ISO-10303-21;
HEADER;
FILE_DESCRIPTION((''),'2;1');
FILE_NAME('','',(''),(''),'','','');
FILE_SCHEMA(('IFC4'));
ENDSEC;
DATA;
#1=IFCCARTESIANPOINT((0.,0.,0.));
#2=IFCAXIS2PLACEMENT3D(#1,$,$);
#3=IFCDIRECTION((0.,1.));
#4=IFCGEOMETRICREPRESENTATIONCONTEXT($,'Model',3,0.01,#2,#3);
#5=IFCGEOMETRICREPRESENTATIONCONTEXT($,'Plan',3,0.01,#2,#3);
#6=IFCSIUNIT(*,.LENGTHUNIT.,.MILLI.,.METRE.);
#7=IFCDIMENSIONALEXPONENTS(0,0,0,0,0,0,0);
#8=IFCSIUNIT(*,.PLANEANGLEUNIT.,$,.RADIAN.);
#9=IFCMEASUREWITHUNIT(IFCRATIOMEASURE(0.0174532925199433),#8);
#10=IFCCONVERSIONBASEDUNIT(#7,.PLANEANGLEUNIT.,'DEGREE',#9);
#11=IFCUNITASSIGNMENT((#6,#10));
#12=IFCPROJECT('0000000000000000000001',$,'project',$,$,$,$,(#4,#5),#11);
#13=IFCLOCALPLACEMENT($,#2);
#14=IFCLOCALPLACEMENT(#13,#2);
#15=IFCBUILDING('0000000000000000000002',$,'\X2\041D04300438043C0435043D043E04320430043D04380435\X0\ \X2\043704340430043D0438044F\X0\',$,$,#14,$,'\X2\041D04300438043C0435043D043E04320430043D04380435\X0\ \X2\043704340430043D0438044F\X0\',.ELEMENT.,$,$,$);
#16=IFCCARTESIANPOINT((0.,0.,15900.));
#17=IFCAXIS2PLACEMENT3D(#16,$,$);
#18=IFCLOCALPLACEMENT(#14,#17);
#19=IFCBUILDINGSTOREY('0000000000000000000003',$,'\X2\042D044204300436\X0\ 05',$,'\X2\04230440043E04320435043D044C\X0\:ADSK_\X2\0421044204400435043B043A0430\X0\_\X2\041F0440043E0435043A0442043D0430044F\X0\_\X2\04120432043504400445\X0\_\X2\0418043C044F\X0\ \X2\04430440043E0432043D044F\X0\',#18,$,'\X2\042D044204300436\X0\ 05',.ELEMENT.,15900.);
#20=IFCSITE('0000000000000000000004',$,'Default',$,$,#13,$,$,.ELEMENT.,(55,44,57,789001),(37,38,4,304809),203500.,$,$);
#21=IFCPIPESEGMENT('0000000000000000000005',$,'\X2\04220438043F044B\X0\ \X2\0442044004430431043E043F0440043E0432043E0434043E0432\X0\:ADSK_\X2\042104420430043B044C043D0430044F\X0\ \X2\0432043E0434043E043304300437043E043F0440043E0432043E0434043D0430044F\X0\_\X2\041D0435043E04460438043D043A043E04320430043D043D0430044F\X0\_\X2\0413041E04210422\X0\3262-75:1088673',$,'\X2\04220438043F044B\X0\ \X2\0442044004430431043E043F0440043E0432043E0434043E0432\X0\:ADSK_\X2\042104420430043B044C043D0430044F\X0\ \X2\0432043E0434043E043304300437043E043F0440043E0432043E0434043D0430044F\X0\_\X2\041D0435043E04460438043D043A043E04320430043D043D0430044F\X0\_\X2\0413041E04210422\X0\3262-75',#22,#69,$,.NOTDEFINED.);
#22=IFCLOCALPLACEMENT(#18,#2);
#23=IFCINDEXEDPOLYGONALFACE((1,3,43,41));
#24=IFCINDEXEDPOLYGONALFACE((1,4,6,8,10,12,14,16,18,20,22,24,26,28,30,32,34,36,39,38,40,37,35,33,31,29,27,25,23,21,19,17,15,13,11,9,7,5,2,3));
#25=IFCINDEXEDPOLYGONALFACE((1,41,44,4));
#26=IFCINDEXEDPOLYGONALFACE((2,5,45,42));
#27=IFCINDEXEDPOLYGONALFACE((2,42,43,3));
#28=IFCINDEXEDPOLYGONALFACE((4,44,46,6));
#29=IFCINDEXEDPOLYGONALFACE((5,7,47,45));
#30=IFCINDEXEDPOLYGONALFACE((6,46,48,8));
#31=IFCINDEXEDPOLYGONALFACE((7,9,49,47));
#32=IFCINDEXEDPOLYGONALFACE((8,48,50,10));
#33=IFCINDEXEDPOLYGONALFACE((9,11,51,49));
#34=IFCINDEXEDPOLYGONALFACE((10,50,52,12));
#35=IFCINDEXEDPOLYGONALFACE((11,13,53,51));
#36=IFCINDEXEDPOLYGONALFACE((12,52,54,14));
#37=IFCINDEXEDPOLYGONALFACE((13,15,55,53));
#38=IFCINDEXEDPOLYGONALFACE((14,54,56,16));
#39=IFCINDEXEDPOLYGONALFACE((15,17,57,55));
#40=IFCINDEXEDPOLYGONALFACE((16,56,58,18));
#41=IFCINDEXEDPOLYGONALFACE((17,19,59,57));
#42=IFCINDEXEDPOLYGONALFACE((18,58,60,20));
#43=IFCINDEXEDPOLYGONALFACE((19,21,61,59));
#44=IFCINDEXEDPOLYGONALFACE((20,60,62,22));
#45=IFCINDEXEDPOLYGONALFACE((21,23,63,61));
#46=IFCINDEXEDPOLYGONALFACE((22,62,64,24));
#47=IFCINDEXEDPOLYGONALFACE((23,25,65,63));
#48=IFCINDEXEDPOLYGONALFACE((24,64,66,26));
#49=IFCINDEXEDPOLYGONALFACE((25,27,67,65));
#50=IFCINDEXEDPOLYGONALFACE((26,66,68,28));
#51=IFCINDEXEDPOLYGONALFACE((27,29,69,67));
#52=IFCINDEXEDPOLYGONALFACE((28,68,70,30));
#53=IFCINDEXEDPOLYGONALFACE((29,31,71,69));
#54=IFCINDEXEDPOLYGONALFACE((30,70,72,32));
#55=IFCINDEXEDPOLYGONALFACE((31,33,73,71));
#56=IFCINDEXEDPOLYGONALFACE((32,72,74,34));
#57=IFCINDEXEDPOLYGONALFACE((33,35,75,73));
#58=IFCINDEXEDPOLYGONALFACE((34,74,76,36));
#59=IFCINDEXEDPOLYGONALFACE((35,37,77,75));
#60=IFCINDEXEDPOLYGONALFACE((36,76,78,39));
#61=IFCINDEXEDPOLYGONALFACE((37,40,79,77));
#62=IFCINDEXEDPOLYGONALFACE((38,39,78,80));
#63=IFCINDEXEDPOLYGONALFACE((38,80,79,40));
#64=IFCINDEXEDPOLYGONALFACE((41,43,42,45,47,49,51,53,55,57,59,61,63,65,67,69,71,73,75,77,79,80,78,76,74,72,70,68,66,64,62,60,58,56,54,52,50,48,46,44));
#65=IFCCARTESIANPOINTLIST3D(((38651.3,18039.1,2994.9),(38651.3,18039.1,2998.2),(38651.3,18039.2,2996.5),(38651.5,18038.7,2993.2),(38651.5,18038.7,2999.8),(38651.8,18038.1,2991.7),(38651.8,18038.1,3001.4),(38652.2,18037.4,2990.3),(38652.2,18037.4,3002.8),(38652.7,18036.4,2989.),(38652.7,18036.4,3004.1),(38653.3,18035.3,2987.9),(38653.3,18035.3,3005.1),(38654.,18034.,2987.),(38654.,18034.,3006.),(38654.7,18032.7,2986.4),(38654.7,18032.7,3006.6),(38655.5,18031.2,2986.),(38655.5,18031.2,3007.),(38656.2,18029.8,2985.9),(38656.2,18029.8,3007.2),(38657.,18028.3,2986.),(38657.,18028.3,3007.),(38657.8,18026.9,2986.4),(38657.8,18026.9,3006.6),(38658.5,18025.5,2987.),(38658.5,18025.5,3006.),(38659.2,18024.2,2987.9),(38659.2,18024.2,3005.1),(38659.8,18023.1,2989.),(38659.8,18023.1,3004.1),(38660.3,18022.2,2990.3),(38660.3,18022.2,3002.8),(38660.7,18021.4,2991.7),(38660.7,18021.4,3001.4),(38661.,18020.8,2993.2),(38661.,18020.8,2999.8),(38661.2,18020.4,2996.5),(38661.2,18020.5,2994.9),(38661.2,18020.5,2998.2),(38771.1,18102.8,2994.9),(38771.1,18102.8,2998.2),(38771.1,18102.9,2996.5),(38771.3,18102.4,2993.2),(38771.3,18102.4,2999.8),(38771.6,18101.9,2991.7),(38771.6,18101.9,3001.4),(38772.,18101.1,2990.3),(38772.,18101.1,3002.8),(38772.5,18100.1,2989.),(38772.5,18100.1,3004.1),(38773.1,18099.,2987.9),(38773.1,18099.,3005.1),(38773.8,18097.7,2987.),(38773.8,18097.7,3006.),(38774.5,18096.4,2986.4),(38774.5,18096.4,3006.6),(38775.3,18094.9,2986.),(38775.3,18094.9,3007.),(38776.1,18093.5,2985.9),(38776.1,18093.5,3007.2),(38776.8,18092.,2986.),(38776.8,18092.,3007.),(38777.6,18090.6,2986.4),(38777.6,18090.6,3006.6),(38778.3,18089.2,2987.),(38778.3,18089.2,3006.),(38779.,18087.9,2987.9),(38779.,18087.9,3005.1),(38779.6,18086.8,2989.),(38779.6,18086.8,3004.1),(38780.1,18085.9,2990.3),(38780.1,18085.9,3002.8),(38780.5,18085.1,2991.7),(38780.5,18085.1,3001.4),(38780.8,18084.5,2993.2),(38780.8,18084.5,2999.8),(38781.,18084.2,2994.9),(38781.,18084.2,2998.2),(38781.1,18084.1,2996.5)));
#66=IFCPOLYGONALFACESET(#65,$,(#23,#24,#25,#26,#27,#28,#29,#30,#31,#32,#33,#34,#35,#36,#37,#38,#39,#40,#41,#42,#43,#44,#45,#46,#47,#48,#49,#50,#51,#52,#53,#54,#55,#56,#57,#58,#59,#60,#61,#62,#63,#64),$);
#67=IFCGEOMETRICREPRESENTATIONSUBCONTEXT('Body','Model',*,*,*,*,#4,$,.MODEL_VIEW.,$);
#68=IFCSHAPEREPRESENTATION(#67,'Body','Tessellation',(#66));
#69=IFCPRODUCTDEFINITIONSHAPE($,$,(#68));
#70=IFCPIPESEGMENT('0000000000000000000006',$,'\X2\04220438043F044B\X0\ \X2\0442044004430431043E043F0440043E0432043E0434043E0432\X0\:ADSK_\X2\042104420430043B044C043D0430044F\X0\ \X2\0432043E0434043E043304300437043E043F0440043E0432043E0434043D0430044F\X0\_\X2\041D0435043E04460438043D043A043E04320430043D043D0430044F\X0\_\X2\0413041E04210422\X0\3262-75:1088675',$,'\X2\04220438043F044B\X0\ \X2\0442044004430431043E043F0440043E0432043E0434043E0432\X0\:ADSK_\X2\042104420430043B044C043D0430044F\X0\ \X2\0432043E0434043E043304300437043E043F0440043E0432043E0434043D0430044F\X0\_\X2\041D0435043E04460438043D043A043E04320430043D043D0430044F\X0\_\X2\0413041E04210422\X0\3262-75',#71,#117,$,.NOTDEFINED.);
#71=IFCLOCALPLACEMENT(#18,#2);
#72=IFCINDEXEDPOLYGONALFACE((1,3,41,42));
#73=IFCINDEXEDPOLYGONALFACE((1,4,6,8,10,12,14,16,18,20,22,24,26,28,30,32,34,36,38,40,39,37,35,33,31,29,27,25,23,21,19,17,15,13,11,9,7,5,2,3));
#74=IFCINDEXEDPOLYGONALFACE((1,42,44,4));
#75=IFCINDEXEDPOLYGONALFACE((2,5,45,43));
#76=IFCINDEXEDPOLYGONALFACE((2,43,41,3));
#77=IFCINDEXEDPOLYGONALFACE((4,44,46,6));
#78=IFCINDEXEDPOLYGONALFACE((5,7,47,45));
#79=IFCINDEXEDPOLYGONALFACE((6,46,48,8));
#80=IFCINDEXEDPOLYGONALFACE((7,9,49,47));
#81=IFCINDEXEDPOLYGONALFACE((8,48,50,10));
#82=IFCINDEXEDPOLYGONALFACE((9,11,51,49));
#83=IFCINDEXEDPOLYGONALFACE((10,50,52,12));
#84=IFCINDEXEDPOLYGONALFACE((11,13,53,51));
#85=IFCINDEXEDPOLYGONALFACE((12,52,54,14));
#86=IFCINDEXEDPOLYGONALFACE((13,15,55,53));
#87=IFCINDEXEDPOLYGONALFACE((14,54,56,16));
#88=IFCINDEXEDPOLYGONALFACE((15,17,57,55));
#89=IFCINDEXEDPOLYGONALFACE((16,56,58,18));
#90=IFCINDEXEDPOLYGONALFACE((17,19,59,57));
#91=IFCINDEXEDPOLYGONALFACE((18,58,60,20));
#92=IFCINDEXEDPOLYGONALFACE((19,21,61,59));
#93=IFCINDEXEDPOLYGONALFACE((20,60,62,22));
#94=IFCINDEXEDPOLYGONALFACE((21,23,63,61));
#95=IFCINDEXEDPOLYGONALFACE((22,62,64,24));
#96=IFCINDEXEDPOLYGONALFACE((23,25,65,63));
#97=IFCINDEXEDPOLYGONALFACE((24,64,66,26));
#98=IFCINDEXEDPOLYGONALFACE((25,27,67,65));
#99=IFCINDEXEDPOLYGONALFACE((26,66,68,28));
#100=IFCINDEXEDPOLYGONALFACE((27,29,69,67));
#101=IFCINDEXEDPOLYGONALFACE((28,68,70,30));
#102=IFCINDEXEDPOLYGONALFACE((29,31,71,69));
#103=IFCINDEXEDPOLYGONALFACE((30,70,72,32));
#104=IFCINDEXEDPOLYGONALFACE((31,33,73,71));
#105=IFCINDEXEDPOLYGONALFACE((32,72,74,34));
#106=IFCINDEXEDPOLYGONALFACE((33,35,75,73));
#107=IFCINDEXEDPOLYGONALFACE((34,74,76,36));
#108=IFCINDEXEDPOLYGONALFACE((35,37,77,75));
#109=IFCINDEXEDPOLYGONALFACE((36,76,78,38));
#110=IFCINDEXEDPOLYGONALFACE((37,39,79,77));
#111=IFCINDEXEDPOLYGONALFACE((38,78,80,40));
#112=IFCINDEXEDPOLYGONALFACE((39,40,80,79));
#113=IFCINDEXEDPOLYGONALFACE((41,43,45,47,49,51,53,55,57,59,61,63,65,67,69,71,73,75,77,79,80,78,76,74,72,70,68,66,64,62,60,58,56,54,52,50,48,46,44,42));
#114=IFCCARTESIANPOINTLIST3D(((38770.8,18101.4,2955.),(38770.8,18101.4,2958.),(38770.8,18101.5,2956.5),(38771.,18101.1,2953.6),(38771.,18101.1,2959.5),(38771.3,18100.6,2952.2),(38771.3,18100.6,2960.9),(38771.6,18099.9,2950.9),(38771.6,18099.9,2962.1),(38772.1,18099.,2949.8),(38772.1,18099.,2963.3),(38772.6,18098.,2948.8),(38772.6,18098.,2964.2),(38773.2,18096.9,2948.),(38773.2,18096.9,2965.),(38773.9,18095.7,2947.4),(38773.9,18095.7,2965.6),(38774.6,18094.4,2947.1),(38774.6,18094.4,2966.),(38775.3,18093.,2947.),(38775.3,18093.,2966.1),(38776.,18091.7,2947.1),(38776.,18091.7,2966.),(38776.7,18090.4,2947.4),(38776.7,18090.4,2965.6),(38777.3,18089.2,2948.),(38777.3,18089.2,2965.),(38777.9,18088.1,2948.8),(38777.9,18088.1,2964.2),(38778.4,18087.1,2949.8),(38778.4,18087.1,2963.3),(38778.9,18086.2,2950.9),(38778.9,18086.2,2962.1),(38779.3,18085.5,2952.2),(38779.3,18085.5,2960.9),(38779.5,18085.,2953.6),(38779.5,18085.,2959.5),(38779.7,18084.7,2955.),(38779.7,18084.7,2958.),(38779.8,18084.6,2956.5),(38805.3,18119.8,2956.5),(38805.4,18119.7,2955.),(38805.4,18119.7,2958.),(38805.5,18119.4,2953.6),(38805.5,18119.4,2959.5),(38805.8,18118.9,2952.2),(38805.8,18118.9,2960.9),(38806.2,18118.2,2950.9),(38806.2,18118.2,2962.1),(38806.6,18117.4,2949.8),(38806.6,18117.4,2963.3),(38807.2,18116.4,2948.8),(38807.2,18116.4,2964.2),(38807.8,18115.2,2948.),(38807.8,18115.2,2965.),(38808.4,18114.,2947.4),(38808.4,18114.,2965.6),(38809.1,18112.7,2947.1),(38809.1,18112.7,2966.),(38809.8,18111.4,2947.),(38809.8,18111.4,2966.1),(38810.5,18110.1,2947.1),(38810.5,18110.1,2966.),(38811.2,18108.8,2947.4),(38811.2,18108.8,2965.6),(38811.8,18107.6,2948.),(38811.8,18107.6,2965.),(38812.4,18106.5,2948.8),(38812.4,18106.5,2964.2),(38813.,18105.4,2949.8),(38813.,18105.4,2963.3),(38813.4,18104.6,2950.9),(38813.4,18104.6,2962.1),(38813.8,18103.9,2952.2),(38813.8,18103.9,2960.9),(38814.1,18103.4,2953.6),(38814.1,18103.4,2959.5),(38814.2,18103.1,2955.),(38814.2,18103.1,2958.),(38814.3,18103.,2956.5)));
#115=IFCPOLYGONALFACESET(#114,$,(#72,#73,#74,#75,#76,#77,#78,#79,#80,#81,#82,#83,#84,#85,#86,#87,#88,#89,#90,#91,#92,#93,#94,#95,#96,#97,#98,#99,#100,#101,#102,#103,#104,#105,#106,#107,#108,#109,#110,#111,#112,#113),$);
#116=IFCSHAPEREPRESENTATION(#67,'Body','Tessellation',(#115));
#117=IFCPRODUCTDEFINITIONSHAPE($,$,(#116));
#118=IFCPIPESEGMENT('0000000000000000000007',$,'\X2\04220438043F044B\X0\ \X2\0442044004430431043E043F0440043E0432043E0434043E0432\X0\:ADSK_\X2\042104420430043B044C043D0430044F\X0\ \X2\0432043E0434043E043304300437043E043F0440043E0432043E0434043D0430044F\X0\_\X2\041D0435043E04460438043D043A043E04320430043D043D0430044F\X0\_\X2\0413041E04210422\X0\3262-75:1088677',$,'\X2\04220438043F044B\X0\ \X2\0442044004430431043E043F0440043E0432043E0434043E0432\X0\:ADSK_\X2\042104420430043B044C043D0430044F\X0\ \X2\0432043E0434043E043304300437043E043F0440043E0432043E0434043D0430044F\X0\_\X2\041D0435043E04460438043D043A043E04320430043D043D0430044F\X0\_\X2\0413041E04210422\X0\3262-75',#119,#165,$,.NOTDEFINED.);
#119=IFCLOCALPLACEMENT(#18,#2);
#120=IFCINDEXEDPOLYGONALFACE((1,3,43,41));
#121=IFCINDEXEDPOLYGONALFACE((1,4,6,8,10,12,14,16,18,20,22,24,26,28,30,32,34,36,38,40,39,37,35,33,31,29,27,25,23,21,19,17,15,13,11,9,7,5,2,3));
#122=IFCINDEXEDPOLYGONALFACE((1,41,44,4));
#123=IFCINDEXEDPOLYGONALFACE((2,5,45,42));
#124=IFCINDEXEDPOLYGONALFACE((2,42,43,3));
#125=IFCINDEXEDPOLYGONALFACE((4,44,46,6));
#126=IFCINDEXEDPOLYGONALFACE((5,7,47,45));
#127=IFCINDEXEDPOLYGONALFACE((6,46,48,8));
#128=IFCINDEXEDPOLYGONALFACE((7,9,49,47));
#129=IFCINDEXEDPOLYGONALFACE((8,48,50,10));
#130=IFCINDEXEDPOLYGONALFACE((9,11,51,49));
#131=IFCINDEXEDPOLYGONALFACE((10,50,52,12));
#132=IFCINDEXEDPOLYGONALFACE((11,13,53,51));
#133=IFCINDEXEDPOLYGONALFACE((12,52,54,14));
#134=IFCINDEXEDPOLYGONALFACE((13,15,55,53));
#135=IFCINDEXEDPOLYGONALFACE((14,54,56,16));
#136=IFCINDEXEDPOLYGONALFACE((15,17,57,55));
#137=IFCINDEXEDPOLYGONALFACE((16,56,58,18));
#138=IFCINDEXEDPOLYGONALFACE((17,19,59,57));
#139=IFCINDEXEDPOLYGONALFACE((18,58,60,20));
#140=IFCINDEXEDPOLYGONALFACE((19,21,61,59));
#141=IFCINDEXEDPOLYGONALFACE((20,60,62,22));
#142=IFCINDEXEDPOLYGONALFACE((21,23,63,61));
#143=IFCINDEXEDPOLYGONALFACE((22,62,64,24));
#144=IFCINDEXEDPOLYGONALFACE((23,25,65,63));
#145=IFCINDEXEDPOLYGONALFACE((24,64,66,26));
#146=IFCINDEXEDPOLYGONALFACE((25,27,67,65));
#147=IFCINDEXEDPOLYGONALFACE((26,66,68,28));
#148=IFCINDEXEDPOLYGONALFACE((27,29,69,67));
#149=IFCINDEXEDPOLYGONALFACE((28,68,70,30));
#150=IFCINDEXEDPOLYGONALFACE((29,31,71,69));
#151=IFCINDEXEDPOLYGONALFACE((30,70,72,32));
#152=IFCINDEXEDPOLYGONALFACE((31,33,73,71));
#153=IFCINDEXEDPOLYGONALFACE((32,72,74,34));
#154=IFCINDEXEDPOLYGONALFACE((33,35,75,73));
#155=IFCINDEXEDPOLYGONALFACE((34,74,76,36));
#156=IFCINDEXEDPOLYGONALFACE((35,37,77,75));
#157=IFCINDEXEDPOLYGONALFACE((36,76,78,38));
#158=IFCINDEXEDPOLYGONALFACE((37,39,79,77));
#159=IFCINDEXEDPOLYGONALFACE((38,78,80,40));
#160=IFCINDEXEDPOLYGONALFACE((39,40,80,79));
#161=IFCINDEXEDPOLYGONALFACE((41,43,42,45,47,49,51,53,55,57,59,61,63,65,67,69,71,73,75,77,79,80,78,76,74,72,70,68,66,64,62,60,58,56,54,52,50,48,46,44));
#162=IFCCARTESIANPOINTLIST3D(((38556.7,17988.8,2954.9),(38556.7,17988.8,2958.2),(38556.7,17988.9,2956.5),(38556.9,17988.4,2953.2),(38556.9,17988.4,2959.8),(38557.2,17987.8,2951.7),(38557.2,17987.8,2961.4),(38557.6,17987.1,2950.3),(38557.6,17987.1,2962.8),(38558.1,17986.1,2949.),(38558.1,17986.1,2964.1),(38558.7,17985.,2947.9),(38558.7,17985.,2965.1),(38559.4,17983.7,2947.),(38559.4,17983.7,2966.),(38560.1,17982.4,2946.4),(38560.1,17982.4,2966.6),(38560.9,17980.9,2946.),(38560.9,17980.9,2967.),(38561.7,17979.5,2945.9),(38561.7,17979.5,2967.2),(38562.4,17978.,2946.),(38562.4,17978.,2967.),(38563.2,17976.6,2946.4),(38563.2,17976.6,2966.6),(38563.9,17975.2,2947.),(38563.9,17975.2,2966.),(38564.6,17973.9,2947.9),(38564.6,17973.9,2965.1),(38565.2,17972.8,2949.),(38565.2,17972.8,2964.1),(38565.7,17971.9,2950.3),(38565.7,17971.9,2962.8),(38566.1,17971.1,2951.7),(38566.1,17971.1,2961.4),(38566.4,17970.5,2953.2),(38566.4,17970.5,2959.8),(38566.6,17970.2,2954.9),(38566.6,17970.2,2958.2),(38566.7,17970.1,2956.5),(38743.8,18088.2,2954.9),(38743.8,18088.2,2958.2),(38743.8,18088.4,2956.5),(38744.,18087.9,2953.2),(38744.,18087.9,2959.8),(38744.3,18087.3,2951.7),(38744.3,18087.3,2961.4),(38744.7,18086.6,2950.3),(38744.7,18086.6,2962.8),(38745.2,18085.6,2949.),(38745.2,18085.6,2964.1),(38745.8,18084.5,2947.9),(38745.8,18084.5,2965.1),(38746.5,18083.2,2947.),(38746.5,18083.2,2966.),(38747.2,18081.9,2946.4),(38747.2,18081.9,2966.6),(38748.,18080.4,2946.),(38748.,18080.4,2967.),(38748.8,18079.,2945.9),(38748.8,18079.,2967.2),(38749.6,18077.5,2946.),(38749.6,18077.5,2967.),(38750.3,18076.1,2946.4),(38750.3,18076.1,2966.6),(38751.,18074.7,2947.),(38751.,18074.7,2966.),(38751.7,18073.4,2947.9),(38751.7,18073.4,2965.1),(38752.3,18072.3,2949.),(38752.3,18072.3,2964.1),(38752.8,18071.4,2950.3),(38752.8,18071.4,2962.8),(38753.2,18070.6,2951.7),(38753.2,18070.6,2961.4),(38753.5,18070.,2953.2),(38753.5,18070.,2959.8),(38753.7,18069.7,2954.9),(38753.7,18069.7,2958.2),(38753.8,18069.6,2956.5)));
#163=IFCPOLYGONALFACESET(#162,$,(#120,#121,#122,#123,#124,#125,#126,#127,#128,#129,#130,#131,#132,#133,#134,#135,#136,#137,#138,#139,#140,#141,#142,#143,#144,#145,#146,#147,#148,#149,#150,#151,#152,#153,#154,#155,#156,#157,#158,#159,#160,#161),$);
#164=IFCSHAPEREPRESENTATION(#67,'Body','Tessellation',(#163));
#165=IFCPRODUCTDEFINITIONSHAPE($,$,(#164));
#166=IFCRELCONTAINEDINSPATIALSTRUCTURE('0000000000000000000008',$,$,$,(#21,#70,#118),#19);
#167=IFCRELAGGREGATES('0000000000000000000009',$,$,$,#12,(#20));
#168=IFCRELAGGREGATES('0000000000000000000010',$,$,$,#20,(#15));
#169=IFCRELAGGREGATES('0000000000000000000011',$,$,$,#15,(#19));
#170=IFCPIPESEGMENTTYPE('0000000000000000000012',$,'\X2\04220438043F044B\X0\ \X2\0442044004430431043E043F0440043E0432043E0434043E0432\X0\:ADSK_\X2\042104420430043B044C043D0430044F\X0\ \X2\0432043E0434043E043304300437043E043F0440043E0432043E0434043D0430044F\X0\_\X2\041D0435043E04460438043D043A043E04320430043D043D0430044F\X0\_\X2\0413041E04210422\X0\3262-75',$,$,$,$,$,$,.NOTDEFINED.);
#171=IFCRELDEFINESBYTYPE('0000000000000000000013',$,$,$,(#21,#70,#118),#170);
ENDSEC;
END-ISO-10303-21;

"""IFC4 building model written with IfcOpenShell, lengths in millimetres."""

from ifc_helpers import new_model, entity, si_unit, converted_unit, direction, frame, origin, place, context, subcontext, project, spatial, indexed_curve, outline, extrude, type_object, element, save


model = new_model("IFC4")

# Units and contexts
model_context = context("Model", 3, precision=0.01, world=origin(), true_north=direction((0.0, 1.0)))
plan_context = context("Plan", 3, precision=0.01, world=origin(), true_north=direction((0.0, 1.0)))
body_context = subcontext(model_context, "Body", "Model", "MODEL_VIEW")
ifc_project = project(units=[si_unit("LENGTHUNIT", "METRE", prefix="MILLI"), converted_unit("PLANEANGLEUNIT", "DEGREE", entity("IfcRatioMeasure", 0.0174532925199433), si_unit("PLANEANGLEUNIT", "RADIAN"), dimensions=[0, 0, 0, 0, 0, 0, 0])], contexts=[model_context, plan_context])

# Site, building, storey
site_placement = place(None, origin())
site = spatial("IfcSite", under=ifc_project, at=site_placement, Name="Default", CompositionType="ELEMENT", RefLatitude=(55, 44, 57, 789001), RefLongitude=(37, 38, 4, 304809), RefElevation=203500.0)
building_placement = place(site_placement, origin())
building = spatial("IfcBuilding", under=site, at=building_placement, Name="Наименование здания", LongName="Наименование здания", CompositionType="ELEMENT")
storey_placement = place(building_placement, frame((0.0, 0.0, 15900.0)))
storey = spatial("IfcBuildingStorey", under=building, at=storey_placement, Name="Этаж 05", ObjectType="Уровень:ADSK_Стрелка_Проектная_Вверх_Имя уровня", LongName="Этаж 05", CompositionType="ELEMENT", Elevation=15900.0)

# Pipe segments
placement = place(storey_placement, origin())
pipe_segment_type_1 = type_object("IfcPipeSegmentType", Name="Типы трубопроводов:ADSK_Стальная водогазопроводная_Неоцинкованная_ГОСТ3262-75", PredefinedType="NOTDEFINED")
element("IfcPipeSegment", 1, at=placement, inside=storey, type_object=pipe_segment_type_1, Name="Типы трубопроводов:ADSK_Стальная водогазопроводная_Неоцинкованная_ГОСТ3262-75:1088673", ObjectType="Типы трубопроводов:ADSK_Стальная водогазопроводная_Неоцинкованная_ГОСТ3262-75", PredefinedType="NOTDEFINED", context=body_context, shape_type="SweptSolid", body=[
    extrude(outline(indexed_curve([(10.7, 0.0), (10.5, 1.7), (10.1, 3.3), (9.5, 4.8), (8.6, 6.3), (7.5, 7.5), (6.3, 8.6), (4.8, 9.5), (3.3, 10.1), (1.7, 10.5), (0.0, 10.6), (-1.7, 10.5), (-3.3, 10.1), (-4.8, 9.5), (-6.3, 8.6), (-7.5, 7.5), (-8.6, 6.3), (-9.5, 4.8), (-10.1, 3.3), (-10.5, 1.7), (-10.7, 0.0), (-10.5, -1.7), (-10.1, -3.3), (-9.5, -4.8), (-8.6, -6.3), (-7.5, -7.5), (-6.3, -8.6), (-4.8, -9.5), (-3.3, -10.1), (-1.7, -10.5), (0.0, -10.6), (1.7, -10.5), (3.3, -10.1), (4.8, -9.5), (6.3, -8.6), (7.5, -7.5), (8.6, -6.3), (9.5, -4.8), (10.1, -3.3), (10.5, -1.7), (10.7, 0.0)], self_intersect=False)), frame((38656.2, 18029.8, 2996.5), z_axis=(0.882948, 0.469472, 0.0), x_axis=(-0.469472, 0.882948, 0.0)), (0.0, 0.0, 1.0), 135.7),
])
element("IfcPipeSegment", 2, at=placement, inside=storey, type_object=pipe_segment_type_1, Name="Типы трубопроводов:ADSK_Стальная водогазопроводная_Неоцинкованная_ГОСТ3262-75:1088675", ObjectType="Типы трубопроводов:ADSK_Стальная водогазопроводная_Неоцинкованная_ГОСТ3262-75", PredefinedType="NOTDEFINED", context=body_context, shape_type="SweptSolid", body=[
    extrude(outline(indexed_curve([(9.6, 0.0), (9.4, 1.5), (9.1, 3.0), (8.5, 4.3), (7.7, 5.6), (6.8, 6.8), (5.6, 7.7), (4.3, 8.5), (3.0, 9.1), (1.5, 9.4), (0.0, 9.5), (-1.5, 9.4), (-3.0, 9.1), (-4.3, 8.5), (-5.6, 7.7), (-6.8, 6.8), (-7.7, 5.6), (-8.5, 4.3), (-9.1, 3.0), (-9.4, 1.5), (-9.6, 0.0), (-9.4, -1.5), (-9.1, -3.0), (-8.5, -4.3), (-7.7, -5.6), (-6.8, -6.8), (-5.6, -7.7), (-4.3, -8.5), (-3.0, -9.1), (-1.5, -9.4), (0.0, -9.6), (1.5, -9.4), (3.0, -9.1), (4.3, -8.5), (5.6, -7.7), (6.8, -6.8), (7.7, -5.6), (8.5, -4.3), (9.1, -3.0), (9.4, -1.5), (9.6, 0.0)], self_intersect=False)), frame((38775.3, 18093.0, 2956.5), z_axis=(0.882948, 0.469472, 0.0), x_axis=(-0.469472, 0.882948, 0.0)), (0.0, 0.0, 1.0), 39.1),
])
element("IfcPipeSegment", 3, at=placement, inside=storey, type_object=pipe_segment_type_1, Name="Типы трубопроводов:ADSK_Стальная водогазопроводная_Неоцинкованная_ГОСТ3262-75:1088677", ObjectType="Типы трубопроводов:ADSK_Стальная водогазопроводная_Неоцинкованная_ГОСТ3262-75", PredefinedType="NOTDEFINED", context=body_context, shape_type="SweptSolid", body=[
    extrude(outline(indexed_curve([(10.6, 0.0), (10.5, 1.7), (10.1, 3.3), (9.5, 4.8), (8.6, 6.3), (7.5, 7.5), (6.3, 8.6), (4.8, 9.5), (3.3, 10.1), (1.7, 10.5), (0.0, 10.6), (-1.7, 10.5), (-3.3, 10.1), (-4.8, 9.5), (-6.3, 8.6), (-7.5, 7.5), (-8.6, 6.3), (-9.5, 4.8), (-10.1, 3.3), (-10.5, 1.7), (-10.7, 0.0), (-10.5, -1.7), (-10.1, -3.3), (-9.5, -4.8), (-8.6, -6.3), (-7.5, -7.5), (-6.3, -8.6), (-4.8, -9.5), (-3.3, -10.1), (-1.7, -10.5), (0.0, -10.7), (1.7, -10.5), (3.3, -10.1), (4.8, -9.5), (6.3, -8.6), (7.5, -7.5), (8.6, -6.3), (9.5, -4.8), (10.1, -3.3), (10.5, -1.7), (10.6, 0.0)], self_intersect=False)), frame((38561.7, 17979.5, 2956.5), z_axis=(0.882948, 0.469472, 0.0), x_axis=(-0.469472, 0.882948, 0.0)), (0.0, 0.0, 1.0), 211.9),
])

save(model, "model.ifc")
